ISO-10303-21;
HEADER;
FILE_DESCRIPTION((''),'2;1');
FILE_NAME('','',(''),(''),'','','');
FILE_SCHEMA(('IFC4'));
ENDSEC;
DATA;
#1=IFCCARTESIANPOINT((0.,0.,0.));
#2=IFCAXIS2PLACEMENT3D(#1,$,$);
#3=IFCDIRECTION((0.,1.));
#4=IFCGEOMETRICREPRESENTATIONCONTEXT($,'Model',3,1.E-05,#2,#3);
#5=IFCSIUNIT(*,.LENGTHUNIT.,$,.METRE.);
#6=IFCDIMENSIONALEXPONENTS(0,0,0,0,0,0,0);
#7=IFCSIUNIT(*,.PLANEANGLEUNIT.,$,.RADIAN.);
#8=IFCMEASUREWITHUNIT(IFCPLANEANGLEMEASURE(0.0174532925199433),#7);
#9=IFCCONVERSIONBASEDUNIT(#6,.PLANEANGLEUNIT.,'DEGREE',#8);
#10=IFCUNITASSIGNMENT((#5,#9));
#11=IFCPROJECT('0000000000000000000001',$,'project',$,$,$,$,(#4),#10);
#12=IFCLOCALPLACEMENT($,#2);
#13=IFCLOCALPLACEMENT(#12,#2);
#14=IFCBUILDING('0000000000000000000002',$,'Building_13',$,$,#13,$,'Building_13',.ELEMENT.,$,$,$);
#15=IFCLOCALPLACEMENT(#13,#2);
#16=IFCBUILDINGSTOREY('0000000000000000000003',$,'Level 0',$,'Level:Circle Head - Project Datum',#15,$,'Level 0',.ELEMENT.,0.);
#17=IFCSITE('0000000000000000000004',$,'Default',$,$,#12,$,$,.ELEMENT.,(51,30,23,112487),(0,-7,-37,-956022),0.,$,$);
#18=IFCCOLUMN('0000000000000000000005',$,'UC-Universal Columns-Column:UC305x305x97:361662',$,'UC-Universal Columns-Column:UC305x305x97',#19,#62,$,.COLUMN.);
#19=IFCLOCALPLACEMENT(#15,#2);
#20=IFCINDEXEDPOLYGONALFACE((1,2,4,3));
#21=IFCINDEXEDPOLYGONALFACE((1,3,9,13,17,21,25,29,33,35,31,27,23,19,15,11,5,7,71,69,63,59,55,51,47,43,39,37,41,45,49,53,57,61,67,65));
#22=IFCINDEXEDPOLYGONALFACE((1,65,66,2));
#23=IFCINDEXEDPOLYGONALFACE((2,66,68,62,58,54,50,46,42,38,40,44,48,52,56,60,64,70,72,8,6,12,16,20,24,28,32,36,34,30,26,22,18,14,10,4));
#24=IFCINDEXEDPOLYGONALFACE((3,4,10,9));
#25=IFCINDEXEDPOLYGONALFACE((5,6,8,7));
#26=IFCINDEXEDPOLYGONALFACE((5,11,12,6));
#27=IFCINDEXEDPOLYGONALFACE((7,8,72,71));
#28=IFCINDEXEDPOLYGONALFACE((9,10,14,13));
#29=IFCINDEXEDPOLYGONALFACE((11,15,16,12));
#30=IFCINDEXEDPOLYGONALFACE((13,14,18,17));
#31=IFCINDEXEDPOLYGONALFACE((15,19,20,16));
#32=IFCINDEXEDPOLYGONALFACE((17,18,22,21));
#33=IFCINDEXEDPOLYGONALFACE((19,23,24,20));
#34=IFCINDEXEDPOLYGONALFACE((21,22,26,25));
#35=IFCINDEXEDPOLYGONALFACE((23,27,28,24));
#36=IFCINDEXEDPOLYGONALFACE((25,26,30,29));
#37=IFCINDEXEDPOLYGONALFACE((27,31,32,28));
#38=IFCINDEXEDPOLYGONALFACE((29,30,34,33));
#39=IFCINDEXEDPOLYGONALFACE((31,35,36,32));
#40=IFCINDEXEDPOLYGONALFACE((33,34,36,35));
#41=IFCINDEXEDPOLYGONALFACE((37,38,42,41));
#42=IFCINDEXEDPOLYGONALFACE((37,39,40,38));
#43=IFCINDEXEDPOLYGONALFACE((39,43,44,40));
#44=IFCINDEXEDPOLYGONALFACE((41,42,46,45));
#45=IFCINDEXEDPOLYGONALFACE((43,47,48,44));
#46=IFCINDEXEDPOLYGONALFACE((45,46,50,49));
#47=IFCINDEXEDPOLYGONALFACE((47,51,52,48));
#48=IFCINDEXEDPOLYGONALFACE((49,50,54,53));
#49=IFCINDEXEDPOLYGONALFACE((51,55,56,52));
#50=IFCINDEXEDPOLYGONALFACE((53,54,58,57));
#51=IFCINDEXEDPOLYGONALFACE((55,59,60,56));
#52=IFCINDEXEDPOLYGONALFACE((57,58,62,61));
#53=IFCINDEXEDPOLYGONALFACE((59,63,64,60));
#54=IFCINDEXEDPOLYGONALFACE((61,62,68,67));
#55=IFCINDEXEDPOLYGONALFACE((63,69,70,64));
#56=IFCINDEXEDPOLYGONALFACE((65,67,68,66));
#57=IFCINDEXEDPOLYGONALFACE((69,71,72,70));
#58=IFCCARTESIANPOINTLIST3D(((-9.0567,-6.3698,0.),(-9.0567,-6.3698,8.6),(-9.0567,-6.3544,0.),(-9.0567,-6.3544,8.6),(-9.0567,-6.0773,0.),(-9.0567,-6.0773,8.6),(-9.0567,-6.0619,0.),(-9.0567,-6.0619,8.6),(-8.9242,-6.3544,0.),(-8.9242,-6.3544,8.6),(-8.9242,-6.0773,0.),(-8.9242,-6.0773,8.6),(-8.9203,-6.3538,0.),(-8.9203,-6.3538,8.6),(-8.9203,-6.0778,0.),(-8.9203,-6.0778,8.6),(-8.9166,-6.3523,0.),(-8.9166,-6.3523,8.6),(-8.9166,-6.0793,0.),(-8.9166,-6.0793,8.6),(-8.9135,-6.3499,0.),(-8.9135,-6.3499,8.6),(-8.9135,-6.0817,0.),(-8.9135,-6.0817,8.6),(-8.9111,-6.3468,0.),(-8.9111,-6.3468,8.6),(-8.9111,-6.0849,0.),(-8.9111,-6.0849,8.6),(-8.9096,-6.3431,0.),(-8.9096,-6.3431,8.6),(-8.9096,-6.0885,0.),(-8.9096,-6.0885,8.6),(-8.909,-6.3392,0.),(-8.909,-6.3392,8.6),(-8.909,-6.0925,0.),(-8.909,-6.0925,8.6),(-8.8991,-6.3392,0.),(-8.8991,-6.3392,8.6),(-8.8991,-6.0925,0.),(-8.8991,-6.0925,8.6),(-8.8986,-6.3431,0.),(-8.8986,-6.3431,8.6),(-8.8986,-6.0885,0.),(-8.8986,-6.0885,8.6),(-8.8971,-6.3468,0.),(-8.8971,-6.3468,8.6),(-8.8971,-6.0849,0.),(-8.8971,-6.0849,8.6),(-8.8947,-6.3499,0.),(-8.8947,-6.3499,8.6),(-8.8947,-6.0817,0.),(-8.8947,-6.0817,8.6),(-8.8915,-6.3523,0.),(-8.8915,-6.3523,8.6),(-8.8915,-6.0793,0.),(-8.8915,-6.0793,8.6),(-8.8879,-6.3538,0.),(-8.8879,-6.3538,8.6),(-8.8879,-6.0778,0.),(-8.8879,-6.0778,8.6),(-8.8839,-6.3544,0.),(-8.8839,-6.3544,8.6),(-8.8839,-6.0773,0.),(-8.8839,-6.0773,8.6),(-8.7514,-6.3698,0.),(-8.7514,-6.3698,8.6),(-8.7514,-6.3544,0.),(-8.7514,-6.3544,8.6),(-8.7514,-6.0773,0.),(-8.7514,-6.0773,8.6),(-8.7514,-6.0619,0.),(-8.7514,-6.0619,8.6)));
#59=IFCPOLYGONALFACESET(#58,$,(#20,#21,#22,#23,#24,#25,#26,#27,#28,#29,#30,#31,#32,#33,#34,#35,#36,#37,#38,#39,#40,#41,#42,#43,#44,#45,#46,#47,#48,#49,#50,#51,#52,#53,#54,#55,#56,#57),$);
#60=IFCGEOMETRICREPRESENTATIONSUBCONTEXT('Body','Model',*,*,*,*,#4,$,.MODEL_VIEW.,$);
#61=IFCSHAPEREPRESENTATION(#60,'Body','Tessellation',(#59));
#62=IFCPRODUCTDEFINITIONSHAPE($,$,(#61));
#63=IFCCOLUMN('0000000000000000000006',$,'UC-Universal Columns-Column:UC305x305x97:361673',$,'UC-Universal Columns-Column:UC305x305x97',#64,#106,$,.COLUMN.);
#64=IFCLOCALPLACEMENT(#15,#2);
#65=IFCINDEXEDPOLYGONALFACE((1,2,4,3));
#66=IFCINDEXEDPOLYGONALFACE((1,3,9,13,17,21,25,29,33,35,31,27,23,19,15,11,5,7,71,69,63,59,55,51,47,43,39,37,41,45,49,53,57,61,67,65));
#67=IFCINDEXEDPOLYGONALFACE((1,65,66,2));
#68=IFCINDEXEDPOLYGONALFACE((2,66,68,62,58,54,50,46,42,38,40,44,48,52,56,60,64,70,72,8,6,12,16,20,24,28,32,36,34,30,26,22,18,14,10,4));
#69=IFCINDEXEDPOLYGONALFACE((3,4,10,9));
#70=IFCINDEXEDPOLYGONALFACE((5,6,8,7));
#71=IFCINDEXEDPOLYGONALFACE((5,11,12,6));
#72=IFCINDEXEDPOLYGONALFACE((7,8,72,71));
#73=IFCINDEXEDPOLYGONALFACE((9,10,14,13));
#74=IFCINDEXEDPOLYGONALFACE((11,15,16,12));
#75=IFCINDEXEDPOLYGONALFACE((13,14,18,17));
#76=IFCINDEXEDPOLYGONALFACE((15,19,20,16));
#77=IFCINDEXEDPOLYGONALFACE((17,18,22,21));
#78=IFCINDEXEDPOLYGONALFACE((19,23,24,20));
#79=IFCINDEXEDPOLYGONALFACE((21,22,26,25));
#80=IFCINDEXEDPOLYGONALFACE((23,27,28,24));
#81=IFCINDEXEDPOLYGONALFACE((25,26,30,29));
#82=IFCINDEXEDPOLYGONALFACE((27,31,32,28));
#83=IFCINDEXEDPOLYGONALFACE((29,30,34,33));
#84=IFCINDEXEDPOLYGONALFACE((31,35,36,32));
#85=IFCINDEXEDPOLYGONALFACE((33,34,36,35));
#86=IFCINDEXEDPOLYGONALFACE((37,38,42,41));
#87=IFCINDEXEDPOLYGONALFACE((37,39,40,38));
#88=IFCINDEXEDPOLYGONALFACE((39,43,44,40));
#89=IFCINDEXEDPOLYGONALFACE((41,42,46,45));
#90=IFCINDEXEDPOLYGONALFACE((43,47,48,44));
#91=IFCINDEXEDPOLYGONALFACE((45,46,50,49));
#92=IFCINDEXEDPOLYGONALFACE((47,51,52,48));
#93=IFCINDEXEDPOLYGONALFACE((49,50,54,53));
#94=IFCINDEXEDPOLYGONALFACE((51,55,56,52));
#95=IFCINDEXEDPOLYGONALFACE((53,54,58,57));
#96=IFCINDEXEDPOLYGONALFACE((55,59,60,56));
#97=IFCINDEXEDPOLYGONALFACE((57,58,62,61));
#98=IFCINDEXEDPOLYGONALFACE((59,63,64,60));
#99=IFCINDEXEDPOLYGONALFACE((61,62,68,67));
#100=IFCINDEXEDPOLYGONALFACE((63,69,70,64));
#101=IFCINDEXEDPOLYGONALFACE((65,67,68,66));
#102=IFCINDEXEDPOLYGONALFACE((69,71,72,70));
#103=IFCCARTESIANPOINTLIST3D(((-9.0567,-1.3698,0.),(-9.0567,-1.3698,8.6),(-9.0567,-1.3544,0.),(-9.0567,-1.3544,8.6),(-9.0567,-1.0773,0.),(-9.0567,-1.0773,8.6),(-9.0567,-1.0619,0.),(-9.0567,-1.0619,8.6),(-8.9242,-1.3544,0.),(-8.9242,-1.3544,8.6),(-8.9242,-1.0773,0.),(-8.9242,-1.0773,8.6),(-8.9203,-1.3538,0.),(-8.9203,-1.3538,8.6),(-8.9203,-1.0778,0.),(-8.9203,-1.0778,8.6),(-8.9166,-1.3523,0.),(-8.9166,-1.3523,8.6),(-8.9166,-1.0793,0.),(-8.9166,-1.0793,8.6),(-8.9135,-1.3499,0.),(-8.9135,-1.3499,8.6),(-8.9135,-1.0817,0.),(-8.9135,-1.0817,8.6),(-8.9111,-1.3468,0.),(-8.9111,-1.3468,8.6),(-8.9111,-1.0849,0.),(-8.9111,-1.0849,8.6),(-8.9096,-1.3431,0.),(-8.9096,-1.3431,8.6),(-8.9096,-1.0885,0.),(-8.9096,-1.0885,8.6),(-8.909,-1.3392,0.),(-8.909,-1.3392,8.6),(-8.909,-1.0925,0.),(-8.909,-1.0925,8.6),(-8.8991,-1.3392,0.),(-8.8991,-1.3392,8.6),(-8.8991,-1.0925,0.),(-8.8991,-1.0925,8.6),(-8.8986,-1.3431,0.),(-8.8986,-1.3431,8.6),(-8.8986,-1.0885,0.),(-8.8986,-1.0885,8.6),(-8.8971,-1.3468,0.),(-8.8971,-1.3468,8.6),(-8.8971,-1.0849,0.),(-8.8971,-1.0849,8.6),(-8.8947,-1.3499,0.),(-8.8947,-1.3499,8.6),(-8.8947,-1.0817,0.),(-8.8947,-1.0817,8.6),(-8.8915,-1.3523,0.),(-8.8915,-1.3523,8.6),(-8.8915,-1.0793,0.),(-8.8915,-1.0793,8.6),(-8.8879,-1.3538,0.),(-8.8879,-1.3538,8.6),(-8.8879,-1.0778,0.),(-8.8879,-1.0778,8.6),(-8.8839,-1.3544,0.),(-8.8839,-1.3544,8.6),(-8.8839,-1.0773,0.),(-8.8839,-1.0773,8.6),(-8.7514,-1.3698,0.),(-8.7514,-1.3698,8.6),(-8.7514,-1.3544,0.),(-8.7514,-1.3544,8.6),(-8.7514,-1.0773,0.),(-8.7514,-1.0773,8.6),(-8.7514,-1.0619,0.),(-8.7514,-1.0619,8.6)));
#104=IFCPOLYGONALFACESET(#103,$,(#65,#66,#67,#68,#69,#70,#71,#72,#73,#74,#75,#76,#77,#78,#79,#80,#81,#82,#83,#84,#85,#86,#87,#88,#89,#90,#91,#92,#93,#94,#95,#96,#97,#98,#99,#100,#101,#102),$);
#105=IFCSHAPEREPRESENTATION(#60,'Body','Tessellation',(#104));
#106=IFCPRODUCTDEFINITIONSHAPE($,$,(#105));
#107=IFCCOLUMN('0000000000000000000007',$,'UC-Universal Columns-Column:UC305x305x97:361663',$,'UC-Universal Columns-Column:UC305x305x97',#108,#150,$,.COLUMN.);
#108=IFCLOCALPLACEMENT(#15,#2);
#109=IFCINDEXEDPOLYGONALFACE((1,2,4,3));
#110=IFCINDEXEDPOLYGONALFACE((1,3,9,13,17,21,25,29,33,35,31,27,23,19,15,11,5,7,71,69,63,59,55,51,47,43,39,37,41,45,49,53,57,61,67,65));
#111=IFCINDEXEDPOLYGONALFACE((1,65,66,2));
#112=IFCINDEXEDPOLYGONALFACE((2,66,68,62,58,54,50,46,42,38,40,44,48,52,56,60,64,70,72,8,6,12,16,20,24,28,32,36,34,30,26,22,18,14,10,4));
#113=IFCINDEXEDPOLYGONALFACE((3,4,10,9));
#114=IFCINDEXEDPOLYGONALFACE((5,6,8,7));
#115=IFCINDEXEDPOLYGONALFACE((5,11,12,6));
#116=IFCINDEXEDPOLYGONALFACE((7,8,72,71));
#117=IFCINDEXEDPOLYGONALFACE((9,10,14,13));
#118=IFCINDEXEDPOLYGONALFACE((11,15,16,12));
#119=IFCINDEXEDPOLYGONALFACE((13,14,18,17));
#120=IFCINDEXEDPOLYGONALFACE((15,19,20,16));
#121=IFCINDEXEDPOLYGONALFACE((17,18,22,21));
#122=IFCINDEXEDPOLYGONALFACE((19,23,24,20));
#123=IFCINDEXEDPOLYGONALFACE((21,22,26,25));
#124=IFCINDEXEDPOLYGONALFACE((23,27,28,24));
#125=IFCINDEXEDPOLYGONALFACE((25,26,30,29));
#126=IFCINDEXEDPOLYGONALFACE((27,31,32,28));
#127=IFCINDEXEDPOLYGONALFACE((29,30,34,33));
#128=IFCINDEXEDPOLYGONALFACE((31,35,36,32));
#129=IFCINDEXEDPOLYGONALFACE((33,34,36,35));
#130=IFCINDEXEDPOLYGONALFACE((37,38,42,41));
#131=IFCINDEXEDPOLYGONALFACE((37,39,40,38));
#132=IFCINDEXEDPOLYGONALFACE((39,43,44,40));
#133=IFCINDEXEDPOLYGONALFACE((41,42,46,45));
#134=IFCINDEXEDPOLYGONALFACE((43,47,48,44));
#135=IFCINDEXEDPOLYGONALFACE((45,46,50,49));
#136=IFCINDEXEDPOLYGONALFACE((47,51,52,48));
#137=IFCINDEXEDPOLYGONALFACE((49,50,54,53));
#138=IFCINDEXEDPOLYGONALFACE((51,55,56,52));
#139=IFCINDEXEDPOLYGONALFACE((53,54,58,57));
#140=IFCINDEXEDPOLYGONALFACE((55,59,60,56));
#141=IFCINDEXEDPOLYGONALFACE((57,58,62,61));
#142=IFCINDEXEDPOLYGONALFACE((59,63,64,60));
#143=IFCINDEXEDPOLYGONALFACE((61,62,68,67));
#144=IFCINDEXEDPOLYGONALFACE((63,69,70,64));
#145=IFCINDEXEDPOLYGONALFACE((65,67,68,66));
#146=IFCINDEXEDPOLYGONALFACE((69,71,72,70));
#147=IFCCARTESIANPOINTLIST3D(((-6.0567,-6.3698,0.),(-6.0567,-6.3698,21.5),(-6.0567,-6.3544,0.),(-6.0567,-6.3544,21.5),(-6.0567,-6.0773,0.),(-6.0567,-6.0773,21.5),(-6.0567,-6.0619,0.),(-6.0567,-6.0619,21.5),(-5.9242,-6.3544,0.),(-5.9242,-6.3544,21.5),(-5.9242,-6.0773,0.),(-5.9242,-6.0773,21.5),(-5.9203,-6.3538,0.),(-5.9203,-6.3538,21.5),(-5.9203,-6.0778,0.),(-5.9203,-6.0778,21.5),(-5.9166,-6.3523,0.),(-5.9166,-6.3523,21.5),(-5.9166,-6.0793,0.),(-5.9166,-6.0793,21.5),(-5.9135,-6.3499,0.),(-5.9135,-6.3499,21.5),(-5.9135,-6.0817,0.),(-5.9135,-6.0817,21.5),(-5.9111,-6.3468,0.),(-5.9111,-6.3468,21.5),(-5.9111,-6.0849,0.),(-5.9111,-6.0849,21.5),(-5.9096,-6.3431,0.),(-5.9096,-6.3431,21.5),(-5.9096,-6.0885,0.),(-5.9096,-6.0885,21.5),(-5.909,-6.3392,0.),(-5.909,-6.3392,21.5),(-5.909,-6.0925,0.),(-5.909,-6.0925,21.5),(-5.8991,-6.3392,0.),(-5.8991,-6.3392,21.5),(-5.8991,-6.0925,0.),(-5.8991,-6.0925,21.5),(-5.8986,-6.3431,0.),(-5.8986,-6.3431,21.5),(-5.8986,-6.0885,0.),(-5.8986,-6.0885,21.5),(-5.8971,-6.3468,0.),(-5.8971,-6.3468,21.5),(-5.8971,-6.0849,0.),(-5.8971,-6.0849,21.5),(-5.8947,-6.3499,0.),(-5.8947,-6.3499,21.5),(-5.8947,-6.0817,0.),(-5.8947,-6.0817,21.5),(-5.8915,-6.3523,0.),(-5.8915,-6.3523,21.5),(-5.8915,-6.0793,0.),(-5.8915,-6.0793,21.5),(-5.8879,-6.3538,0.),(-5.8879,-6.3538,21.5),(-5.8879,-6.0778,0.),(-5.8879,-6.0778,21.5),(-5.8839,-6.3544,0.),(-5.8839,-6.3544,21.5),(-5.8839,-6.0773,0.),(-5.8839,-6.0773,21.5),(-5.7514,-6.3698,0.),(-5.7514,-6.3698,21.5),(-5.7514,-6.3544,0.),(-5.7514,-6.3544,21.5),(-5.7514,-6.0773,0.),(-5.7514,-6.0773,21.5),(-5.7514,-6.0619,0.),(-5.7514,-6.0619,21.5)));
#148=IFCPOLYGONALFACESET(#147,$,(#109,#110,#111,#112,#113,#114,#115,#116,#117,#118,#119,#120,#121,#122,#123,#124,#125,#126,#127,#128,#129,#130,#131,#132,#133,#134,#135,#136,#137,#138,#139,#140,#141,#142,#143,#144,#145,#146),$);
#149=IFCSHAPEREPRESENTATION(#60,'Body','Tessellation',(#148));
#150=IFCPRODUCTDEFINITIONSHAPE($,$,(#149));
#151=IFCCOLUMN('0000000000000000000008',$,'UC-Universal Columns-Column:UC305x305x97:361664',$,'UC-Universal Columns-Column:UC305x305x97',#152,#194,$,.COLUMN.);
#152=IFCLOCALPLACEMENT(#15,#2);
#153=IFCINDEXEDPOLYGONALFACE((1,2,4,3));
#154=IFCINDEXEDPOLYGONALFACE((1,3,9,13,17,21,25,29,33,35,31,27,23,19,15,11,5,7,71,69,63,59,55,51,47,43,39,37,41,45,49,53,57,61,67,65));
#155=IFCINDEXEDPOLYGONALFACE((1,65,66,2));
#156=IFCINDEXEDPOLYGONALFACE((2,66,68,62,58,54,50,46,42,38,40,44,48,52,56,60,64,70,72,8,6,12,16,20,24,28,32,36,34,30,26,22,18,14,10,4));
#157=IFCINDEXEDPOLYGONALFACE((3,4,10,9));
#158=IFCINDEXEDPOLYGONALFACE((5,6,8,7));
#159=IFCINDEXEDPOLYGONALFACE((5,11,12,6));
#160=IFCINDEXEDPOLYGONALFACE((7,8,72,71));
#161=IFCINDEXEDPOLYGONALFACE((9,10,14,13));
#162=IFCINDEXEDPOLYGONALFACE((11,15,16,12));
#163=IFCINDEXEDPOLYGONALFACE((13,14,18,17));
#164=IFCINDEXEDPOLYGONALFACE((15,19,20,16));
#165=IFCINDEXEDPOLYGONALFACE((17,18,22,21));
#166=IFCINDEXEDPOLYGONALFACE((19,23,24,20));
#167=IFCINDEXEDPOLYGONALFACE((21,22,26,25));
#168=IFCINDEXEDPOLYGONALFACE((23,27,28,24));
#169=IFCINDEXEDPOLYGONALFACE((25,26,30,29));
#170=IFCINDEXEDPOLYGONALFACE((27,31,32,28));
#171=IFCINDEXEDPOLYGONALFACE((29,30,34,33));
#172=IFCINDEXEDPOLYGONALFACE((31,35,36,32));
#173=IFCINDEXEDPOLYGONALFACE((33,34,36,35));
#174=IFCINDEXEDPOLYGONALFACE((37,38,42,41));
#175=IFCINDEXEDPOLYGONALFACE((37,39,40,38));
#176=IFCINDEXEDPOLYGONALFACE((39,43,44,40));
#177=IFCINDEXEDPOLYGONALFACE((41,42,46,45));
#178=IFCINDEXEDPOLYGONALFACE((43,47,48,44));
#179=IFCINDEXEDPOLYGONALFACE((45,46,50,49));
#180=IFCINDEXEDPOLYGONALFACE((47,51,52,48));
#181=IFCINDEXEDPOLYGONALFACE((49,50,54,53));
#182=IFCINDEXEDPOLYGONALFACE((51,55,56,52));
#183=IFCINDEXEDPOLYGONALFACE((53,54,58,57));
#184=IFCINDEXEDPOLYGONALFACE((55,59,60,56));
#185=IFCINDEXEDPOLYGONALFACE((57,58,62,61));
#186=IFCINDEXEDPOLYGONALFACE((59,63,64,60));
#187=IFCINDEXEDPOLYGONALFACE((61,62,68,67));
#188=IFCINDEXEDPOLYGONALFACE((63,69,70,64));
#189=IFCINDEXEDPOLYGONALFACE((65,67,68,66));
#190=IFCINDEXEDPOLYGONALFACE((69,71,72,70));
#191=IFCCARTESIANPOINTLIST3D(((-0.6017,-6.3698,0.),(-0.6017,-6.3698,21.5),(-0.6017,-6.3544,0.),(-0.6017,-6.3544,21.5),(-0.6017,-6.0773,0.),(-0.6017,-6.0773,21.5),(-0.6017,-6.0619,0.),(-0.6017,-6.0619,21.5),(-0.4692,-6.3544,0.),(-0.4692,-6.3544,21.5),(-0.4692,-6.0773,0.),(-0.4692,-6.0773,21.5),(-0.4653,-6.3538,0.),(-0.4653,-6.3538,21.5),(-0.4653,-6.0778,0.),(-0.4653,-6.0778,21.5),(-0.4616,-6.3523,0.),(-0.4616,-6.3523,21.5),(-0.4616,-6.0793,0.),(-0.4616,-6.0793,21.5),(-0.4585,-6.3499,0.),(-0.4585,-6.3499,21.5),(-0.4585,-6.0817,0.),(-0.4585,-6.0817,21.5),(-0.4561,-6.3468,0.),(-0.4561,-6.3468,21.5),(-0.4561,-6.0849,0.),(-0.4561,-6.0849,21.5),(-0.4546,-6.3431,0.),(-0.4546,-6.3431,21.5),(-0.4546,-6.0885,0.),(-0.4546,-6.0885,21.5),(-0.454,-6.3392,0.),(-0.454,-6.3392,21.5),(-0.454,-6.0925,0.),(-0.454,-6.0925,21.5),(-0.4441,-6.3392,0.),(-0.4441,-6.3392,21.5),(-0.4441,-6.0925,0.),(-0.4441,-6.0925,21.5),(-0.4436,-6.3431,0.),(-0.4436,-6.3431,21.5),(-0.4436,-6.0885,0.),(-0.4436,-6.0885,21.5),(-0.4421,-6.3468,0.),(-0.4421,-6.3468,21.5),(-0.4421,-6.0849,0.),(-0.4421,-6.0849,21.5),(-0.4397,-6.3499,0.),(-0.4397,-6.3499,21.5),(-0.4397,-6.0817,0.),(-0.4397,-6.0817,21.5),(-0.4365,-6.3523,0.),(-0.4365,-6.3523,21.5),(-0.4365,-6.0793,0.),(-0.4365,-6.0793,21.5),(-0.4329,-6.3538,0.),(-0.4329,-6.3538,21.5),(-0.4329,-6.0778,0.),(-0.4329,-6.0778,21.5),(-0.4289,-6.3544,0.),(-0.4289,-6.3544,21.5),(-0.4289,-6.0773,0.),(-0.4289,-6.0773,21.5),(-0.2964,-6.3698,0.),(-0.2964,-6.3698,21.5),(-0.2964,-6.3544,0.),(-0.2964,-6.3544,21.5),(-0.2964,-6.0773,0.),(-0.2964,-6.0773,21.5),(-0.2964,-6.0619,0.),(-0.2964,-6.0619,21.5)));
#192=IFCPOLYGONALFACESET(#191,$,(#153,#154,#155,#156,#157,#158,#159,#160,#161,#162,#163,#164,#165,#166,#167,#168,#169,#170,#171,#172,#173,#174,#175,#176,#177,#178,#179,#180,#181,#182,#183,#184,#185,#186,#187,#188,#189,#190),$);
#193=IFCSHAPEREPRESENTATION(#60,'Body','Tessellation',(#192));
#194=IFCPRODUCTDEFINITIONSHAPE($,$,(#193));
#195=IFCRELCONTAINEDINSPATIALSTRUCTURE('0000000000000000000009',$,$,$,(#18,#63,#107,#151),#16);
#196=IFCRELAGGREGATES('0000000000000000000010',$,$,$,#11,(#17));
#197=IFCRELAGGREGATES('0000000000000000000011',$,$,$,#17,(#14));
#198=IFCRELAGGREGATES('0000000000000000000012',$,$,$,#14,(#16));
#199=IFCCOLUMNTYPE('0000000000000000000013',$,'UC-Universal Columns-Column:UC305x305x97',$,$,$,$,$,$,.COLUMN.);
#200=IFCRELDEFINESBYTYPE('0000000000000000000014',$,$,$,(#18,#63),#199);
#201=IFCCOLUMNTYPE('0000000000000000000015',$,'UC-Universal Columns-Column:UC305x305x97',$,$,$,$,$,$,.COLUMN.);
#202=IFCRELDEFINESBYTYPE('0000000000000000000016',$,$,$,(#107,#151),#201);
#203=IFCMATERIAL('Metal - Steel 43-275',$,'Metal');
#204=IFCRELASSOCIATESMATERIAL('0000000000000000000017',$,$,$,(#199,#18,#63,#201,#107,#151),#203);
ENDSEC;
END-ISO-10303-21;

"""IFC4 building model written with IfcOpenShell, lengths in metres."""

from ifc_helpers import new_model, entity, si_unit, converted_unit, direction, frame, origin, place, context, subcontext, project, spatial, line, arc, indexed_curve, outline, extrude, source, transform, mapped, material, type_object, type_shapes, element, save


model = new_model("IFC4")

# Units and contexts
model_context = context("Model", 3, precision=1e-05, world=origin(), true_north=direction((0.0, 1.0)))
body_context = subcontext(model_context, "Body", "Model", "MODEL_VIEW")
ifc_project = project(units=[si_unit("LENGTHUNIT", "METRE"), converted_unit("PLANEANGLEUNIT", "DEGREE", entity("IfcPlaneAngleMeasure", 0.0174532925199433), si_unit("PLANEANGLEUNIT", "RADIAN"), dimensions=[0, 0, 0, 0, 0, 0, 0])], contexts=[model_context])

# Site, building, storey
site_placement = place(None, origin())
site = spatial("IfcSite", under=ifc_project, at=site_placement, Name="Default", CompositionType="ELEMENT", RefLatitude=(51, 30, 23, 112487), RefLongitude=(0, -7, -37, -956022), RefElevation=0.0)
building_placement = place(site_placement, origin())
building = spatial("IfcBuilding", under=site, at=building_placement, Name="Building_13", LongName="Building_13", CompositionType="ELEMENT")
storey_placement = place(building_placement, origin())
storey = spatial("IfcBuildingStorey", under=building, at=storey_placement, Name="Level 0", ObjectType="Level:Circle Head - Project Datum", LongName="Level 0", CompositionType="ELEMENT", Elevation=0.0)

# Columns
ifc_material_1 = material(Name="Metal - Steel 43-275", Category="Metal")
column_type_1 = type_object("IfcColumnType", Name="UC-Universal Columns-Column:UC305x305x97", PredefinedType="COLUMN", material=ifc_material_1)
shared_shape_1 = source(origin(), body_context, "Body", "SweptSolid", [
    extrude(outline(indexed_curve([(-0.154, -0.1527), (-0.1386, -0.1527), (-0.1386, -0.0201), (-0.1341, -0.0094), (-0.1234, -0.005), (0.1234, -0.005), (0.1341, -0.0094), (0.1386, -0.0202), (0.1386, -0.1527), (0.154, -0.1527), (0.154, 0.1527), (0.1386, 0.1527), (0.1386, 0.0201), (0.1341, 0.0094), (0.1234, 0.0049), (-0.1234, 0.0049), (-0.1341, 0.0094), (-0.1386, 0.0202), (-0.1386, 0.1527), (-0.154, 0.1527)], segments=[line(1, 2, 3), arc(3, 4, 5), line(5, 6), arc(6, 7, 8), line(8, 9, 10, 11, 12, 13), arc(13, 14, 15), line(15, 16), arc(16, 17, 18), line(18, 19, 20, 1)], self_intersect=False)), frame((0.0, 0.0, 0.0), z_axis=(0.0, 0.0, 1.0), x_axis=(0.0, 1.0, 0.0)), (0.0, 0.0, 1.0), 8.6),
])
type_shapes(column_type_1, [shared_shape_1])
for number, where, name in (
    (1, (-8.9041, -6.2158, 0.0), "UC-Universal Columns-Column:UC305x305x97:361662"),
    (2, (-8.9041, -1.2158, 0.0), "UC-Universal Columns-Column:UC305x305x97:361673"),
):
    element("IfcColumn", number, at=place(storey_placement, frame(where)), inside=storey, type_object=column_type_1, material=ifc_material_1, Name=name, ObjectType="UC-Universal Columns-Column:UC305x305x97", PredefinedType="COLUMN", context=body_context, shape_type="MappedRepresentation", body=[
        mapped(shared_shape_1, transform((0.0, 0.0, 0.0), scale=1.0)),
    ])
column_type_2 = type_object("IfcColumnType", Name="UC-Universal Columns-Column:UC305x305x97", PredefinedType="COLUMN", material=ifc_material_1)
shared_shape_2 = source(origin(), body_context, "Body", "SweptSolid", [
    extrude(outline(indexed_curve([(-0.154, -0.1527), (-0.1386, -0.1527), (-0.1386, -0.0201), (-0.1341, -0.0094), (-0.1234, -0.005), (0.1234, -0.005), (0.1341, -0.0094), (0.1386, -0.0202), (0.1386, -0.1527), (0.154, -0.1527), (0.154, 0.1527), (0.1386, 0.1527), (0.1386, 0.0201), (0.1341, 0.0094), (0.1234, 0.0049), (-0.1234, 0.0049), (-0.1341, 0.0094), (-0.1386, 0.0202), (-0.1386, 0.1527), (-0.154, 0.1527)], segments=[line(1, 2, 3), arc(3, 4, 5), line(5, 6), arc(6, 7, 8), line(8, 9, 10, 11, 12, 13), arc(13, 14, 15), line(15, 16), arc(16, 17, 18), line(18, 19, 20, 1)], self_intersect=False)), frame((0.0, 0.0, 0.0), z_axis=(0.0, 0.0, 1.0), x_axis=(0.0, 1.0, 0.0)), (0.0, 0.0, 1.0), 21.5),
])
type_shapes(column_type_2, [shared_shape_2])
for number, where, name in (
    (3, (-5.9041, -6.2158, 0.0), "UC-Universal Columns-Column:UC305x305x97:361663"),
    (4, (-0.4491, -6.2158, 0.0), "UC-Universal Columns-Column:UC305x305x97:361664"),
):
    element("IfcColumn", number, at=place(storey_placement, frame(where)), inside=storey, type_object=column_type_2, material=ifc_material_1, Name=name, ObjectType="UC-Universal Columns-Column:UC305x305x97", PredefinedType="COLUMN", context=body_context, shape_type="MappedRepresentation", body=[
        mapped(shared_shape_2, transform((0.0, 0.0, 0.0), scale=1.0)),
    ])

save(model, "model.ifc")
